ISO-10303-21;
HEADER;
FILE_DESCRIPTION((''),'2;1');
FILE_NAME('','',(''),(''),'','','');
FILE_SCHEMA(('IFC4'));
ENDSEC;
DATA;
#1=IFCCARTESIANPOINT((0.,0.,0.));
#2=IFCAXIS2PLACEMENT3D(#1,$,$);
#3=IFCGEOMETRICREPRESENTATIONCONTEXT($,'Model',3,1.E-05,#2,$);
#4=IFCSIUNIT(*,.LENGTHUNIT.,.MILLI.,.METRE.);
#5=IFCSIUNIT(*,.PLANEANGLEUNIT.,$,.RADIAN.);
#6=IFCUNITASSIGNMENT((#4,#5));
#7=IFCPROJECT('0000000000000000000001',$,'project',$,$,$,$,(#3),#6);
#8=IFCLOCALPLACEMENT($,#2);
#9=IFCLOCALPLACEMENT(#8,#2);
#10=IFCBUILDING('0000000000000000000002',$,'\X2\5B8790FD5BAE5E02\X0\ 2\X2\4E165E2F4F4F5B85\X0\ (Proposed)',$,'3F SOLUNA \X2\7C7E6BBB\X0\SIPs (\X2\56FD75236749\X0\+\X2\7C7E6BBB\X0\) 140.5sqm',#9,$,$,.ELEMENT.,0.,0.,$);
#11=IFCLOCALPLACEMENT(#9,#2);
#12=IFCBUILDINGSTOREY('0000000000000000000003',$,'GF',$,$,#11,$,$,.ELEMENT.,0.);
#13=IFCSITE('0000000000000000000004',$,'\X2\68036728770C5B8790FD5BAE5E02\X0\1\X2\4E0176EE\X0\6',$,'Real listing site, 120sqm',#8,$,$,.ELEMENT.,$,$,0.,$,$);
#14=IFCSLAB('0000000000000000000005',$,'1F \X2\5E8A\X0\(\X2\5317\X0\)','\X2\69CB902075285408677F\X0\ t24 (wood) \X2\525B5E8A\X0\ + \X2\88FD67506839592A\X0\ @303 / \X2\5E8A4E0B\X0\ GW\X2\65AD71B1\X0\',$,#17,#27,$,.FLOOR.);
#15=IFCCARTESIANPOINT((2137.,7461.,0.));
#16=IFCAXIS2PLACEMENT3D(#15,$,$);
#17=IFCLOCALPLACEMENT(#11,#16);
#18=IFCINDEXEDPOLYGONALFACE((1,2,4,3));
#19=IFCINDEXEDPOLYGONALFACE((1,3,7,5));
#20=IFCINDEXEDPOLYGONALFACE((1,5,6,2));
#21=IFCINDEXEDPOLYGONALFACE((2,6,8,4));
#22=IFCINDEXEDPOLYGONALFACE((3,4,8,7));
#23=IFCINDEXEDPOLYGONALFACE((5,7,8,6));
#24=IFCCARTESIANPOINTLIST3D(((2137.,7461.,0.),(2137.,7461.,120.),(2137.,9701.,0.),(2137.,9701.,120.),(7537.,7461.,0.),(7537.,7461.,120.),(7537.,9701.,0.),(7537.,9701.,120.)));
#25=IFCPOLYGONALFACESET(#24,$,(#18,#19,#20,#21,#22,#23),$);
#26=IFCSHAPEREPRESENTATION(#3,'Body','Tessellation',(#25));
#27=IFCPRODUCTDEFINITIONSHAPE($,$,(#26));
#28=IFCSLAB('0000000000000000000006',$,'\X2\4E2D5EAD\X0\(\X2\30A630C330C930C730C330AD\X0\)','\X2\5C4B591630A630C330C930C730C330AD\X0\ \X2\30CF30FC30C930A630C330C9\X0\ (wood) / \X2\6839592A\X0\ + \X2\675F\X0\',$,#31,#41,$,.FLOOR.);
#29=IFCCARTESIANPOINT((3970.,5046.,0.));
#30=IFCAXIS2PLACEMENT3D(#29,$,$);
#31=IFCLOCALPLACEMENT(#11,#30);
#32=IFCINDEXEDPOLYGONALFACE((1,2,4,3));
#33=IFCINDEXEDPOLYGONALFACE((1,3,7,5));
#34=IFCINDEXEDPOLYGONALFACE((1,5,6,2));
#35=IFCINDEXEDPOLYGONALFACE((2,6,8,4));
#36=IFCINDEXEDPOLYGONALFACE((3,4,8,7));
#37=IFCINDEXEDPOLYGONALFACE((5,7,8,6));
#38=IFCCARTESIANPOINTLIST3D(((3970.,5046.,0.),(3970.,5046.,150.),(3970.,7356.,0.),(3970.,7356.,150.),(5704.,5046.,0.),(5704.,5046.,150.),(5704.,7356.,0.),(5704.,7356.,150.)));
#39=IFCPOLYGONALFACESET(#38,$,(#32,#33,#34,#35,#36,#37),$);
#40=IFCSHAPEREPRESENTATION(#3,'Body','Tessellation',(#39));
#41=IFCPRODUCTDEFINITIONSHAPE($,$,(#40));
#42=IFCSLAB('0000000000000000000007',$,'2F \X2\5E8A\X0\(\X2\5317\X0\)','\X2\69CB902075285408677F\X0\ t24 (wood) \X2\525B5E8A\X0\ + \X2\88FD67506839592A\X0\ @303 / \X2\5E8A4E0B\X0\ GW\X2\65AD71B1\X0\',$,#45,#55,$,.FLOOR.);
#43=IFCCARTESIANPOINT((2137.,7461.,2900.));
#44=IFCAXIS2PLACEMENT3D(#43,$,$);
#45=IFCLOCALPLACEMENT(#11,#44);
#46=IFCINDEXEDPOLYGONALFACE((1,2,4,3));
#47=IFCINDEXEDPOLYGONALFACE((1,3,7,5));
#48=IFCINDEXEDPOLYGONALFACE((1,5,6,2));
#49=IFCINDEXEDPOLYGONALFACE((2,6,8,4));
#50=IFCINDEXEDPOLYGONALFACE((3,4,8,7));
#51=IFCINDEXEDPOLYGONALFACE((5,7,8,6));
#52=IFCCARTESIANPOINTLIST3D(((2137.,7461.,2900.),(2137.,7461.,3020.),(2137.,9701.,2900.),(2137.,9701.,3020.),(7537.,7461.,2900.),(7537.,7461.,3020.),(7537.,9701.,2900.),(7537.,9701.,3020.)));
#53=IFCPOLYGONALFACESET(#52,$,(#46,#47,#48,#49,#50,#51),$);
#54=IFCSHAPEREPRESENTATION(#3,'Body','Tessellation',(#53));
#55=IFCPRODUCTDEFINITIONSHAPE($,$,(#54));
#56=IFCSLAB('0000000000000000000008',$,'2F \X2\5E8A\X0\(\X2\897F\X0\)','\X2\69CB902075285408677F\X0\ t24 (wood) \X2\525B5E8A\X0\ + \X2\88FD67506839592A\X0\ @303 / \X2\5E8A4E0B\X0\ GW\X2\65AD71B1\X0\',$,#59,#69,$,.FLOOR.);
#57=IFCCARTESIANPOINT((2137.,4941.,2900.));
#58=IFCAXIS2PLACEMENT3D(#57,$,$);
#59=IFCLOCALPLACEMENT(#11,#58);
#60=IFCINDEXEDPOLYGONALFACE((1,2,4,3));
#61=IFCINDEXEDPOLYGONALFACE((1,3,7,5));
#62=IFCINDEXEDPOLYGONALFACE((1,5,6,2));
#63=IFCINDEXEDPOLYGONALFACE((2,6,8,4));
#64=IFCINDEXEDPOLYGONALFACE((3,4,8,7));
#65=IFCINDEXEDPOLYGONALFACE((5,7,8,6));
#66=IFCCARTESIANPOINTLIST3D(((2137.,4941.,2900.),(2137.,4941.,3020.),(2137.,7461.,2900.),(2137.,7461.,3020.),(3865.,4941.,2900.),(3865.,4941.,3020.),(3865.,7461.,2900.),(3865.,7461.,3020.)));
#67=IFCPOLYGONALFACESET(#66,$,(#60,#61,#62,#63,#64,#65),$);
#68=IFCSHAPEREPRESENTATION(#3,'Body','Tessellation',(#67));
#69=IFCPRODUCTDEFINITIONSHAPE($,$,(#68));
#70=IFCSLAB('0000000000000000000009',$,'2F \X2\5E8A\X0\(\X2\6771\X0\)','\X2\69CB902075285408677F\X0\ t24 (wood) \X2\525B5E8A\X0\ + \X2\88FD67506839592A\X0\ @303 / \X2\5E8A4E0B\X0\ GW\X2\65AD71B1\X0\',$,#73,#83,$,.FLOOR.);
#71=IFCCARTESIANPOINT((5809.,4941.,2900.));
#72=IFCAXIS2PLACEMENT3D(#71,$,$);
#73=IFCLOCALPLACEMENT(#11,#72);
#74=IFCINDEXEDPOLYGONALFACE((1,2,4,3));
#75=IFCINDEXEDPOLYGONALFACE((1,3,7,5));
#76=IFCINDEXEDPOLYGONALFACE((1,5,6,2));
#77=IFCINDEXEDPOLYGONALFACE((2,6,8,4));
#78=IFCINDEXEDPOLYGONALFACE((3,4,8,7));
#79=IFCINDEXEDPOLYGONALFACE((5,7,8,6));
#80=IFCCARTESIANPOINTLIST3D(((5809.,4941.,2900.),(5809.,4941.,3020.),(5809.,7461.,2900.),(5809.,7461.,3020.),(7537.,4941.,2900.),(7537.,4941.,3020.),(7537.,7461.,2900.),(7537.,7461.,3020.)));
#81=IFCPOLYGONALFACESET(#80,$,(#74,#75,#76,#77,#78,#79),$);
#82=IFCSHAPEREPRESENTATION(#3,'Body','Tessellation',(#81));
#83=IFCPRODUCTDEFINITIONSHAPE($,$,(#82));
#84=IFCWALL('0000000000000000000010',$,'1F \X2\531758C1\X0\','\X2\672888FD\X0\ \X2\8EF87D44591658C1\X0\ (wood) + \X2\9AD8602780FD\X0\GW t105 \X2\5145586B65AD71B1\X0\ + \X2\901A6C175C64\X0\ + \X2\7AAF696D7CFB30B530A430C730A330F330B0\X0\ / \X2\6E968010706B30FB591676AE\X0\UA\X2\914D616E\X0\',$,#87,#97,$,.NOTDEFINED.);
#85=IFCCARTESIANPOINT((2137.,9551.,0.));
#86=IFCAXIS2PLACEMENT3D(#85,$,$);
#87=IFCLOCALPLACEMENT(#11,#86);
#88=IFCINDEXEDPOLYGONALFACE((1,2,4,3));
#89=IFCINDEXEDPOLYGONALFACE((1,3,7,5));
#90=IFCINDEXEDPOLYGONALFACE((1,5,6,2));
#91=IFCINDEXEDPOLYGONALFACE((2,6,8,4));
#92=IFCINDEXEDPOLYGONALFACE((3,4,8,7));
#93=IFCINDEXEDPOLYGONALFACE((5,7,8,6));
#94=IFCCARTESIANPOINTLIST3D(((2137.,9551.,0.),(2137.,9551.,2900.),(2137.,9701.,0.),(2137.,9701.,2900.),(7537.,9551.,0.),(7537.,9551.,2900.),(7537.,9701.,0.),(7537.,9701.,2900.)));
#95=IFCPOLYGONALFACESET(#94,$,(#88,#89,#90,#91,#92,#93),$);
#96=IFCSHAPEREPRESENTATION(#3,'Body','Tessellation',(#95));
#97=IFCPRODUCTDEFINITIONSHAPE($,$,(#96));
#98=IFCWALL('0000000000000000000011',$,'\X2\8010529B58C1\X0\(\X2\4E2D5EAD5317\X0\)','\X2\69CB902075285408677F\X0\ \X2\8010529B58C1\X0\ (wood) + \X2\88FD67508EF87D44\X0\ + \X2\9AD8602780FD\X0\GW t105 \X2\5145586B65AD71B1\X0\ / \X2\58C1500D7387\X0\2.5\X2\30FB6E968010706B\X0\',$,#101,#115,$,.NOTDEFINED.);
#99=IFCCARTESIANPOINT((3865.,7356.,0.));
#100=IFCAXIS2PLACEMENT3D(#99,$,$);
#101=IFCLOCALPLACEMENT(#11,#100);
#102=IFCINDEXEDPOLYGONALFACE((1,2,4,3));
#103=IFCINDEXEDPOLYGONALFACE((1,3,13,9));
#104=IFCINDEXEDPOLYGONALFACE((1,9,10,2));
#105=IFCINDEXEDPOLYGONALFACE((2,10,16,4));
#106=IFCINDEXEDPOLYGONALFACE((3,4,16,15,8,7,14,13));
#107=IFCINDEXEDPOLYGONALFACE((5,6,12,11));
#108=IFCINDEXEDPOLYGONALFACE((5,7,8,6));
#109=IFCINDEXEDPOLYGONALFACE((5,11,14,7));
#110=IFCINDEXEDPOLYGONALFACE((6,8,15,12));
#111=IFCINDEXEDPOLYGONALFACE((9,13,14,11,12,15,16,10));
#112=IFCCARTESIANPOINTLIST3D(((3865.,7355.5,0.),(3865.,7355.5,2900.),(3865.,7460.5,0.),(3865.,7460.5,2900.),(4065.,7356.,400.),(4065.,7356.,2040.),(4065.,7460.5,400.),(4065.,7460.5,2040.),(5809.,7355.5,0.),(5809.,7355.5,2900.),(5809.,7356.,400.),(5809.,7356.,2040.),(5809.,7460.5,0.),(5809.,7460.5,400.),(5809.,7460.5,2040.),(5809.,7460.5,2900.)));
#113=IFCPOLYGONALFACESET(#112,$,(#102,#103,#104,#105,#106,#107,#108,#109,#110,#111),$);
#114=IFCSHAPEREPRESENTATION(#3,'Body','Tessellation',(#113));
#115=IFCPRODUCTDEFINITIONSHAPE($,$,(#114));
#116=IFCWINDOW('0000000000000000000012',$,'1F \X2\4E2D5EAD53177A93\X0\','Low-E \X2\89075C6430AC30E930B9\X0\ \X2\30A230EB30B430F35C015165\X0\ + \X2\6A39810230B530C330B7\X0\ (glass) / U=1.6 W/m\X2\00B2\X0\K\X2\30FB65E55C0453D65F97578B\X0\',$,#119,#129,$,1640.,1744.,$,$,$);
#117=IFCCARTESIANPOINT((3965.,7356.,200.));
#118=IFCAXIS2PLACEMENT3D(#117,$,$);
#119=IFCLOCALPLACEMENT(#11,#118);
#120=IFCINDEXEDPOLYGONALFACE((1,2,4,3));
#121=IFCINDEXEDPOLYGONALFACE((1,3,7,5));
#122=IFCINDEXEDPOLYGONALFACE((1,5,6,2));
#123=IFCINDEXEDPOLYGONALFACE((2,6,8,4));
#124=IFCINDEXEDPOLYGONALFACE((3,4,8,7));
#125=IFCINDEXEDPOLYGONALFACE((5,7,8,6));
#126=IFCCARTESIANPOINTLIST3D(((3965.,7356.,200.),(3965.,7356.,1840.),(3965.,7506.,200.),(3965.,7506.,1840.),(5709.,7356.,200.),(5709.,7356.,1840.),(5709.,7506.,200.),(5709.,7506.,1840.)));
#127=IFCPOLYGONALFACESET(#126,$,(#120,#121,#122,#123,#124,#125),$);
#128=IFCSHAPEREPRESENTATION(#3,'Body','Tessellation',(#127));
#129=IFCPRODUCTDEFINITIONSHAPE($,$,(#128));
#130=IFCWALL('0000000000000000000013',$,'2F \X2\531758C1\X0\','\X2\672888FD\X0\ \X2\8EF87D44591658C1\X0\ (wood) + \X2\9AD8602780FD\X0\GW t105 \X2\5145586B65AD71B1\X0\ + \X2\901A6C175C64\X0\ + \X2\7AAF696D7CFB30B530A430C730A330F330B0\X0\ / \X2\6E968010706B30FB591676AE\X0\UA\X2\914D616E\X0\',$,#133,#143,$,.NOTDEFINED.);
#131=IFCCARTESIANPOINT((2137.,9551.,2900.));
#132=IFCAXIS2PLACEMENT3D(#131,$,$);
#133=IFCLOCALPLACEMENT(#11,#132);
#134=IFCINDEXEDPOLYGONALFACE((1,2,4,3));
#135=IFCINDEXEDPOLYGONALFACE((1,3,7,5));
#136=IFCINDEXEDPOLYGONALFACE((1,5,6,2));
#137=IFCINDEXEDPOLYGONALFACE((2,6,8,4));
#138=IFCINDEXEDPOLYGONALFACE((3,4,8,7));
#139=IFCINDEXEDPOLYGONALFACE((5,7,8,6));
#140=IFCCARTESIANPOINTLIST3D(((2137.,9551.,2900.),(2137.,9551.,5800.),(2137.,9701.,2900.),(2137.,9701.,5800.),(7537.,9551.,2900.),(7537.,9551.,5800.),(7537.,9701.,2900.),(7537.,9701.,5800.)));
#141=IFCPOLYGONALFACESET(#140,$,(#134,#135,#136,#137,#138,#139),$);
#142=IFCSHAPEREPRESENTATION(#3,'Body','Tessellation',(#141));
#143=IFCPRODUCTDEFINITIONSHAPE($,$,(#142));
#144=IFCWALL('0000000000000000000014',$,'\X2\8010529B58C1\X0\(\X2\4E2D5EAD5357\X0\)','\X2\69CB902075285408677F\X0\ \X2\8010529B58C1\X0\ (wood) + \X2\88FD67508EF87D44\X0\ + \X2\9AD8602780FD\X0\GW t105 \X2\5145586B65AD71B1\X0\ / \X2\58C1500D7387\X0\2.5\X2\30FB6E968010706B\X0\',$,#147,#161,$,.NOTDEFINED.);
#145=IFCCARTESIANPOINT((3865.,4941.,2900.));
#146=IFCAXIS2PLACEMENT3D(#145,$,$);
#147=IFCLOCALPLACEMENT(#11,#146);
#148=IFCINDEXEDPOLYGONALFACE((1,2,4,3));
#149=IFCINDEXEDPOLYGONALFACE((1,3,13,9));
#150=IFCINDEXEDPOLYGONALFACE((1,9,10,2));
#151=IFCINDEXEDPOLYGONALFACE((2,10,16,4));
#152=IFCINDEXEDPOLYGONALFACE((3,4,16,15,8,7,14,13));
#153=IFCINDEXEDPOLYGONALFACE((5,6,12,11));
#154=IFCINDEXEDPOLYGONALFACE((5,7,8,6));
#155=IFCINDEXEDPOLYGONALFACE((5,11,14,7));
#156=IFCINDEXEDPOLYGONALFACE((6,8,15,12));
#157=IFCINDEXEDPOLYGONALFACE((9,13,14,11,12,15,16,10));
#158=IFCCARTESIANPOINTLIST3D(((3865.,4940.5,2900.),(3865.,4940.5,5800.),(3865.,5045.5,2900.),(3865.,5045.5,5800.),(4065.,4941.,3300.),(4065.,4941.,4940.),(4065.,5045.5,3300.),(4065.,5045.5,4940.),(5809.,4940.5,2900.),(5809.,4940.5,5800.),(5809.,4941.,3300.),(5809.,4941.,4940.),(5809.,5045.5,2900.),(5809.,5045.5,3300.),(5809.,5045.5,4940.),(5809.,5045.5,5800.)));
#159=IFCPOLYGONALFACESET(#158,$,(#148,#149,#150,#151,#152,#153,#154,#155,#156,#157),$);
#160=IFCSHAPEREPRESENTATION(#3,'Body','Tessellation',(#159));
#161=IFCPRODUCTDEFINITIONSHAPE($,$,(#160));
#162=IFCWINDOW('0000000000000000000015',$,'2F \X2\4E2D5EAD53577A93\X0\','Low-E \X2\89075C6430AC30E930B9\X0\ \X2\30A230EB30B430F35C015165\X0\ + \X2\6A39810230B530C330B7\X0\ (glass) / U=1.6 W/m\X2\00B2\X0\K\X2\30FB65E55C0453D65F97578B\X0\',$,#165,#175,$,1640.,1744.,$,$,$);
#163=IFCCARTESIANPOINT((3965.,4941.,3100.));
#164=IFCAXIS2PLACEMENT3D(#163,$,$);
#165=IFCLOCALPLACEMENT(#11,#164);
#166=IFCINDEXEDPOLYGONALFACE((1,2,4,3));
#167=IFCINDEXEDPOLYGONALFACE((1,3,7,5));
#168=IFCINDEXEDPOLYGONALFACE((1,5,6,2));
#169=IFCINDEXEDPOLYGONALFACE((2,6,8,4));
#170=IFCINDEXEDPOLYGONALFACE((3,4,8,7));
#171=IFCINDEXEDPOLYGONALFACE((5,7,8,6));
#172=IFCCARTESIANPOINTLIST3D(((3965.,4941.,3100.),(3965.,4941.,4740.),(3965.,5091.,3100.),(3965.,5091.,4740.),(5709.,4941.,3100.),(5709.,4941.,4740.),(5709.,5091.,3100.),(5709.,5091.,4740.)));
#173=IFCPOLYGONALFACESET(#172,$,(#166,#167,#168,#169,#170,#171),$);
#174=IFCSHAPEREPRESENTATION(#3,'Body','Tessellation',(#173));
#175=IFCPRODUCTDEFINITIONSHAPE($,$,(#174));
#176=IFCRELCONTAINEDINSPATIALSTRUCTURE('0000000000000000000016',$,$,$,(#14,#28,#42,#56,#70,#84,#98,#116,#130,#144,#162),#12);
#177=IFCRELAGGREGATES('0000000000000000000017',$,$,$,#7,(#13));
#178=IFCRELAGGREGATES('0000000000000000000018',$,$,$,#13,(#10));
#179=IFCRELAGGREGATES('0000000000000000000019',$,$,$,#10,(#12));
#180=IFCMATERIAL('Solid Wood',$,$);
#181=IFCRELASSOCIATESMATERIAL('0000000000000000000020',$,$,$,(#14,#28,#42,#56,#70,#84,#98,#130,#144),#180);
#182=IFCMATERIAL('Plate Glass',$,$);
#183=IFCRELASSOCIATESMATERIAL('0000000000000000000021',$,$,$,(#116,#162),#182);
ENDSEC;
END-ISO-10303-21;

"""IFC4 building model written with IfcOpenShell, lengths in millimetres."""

from ifc_helpers import new_model, si_unit, frame, frame_2d, origin, place, context, project, spatial, rectangle, extrude, material, element, fill, save


model = new_model("IFC4")

# Units and contexts
model_context = context("Model", 3, precision=1e-05, world=origin())
ifc_project = project(units=[si_unit("LENGTHUNIT", "METRE", prefix="MILLI"), si_unit("PLANEANGLEUNIT", "RADIAN")], contexts=[model_context])

# Site, building, storey
site_placement = place(None, origin())
site = spatial("IfcSite", under=ifc_project, at=site_placement, Name="栃木県宇都宮市1丁目6", ObjectType="Real listing site, 120sqm", CompositionType="ELEMENT", RefElevation=0.0)
building_placement = place(site_placement, origin())
building = spatial("IfcBuilding", under=site, at=building_placement, Name="宇都宮市 2世帯住宅 (Proposed)", ObjectType="3F SOLUNA 籾殻SIPs (国産杉+籾殻) 140.5sqm", CompositionType="ELEMENT", ElevationOfRefHeight=0.0, ElevationOfTerrain=0.0)
storey_placement = place(building_placement, origin())
storey = spatial("IfcBuildingStorey", under=building, at=storey_placement, Name="GF", CompositionType="ELEMENT", Elevation=0.0)

# Slabs
ifc_material_1 = material(Name="Solid Wood")
slab_1_placement = place(storey_placement, frame((2137.0, 7461.0, 0.0)))
element("IfcSlab", 1, at=slab_1_placement, inside=storey, material=ifc_material_1, Name="1F 床(北)", Description="構造用合板 t24 (wood) 剛床 + 製材根太 @303 / 床下 GW断熱", PredefinedType="FLOOR", context=model_context, shape_type="SweptSolid", body=[
    extrude(rectangle(XDim=5400.0, YDim=2240.0, at=frame_2d((2700.0, 1120.0))), frame((2137.0, 7461.0, 0.0)), (0.0, 0.0, 1.0), 120.0),
])
slab_2_placement = place(storey_placement, frame((3970.0, 5046.0, 0.0)))
element("IfcSlab", 2, at=slab_2_placement, inside=storey, material=ifc_material_1, Name="中庭(ウッドデッキ)", Description="屋外ウッドデッキ ハードウッド (wood) / 根太 + 束", PredefinedType="FLOOR", context=model_context, shape_type="SweptSolid", body=[
    extrude(rectangle(XDim=1734.0, YDim=2310.0, at=frame_2d((867.0, 1155.0))), frame((3970.0, 5046.0, 0.0)), (0.0, 0.0, 1.0), 150.0),
])
slab_3_placement = place(storey_placement, frame((2137.0, 7461.0, 2900.0)))
element("IfcSlab", 3, at=slab_3_placement, inside=storey, material=ifc_material_1, Name="2F 床(北)", Description="構造用合板 t24 (wood) 剛床 + 製材根太 @303 / 床下 GW断熱", PredefinedType="FLOOR", context=model_context, shape_type="SweptSolid", body=[
    extrude(rectangle(XDim=5400.0, YDim=2240.0, at=frame_2d((2700.0, 1120.0))), frame((2137.0, 7461.0, 2900.0)), (0.0, 0.0, 1.0), 120.0),
])
slab_4_placement = place(storey_placement, frame((2137.0, 4941.0, 2900.0)))
element("IfcSlab", 4, at=slab_4_placement, inside=storey, material=ifc_material_1, Name="2F 床(西)", Description="構造用合板 t24 (wood) 剛床 + 製材根太 @303 / 床下 GW断熱", PredefinedType="FLOOR", context=model_context, shape_type="SweptSolid", body=[
    extrude(rectangle(XDim=1728.0, YDim=2520.0, at=frame_2d((864.0, 1260.0))), frame((2137.0, 4941.0, 2900.0)), (0.0, 0.0, 1.0), 120.0),
])
slab_5_placement = place(storey_placement, frame((5809.0, 4941.0, 2900.0)))
element("IfcSlab", 5, at=slab_5_placement, inside=storey, material=ifc_material_1, Name="2F 床(東)", Description="構造用合板 t24 (wood) 剛床 + 製材根太 @303 / 床下 GW断熱", PredefinedType="FLOOR", context=model_context, shape_type="SweptSolid", body=[
    extrude(rectangle(XDim=1728.0, YDim=2520.0, at=frame_2d((864.0, 1260.0))), frame((5809.0, 4941.0, 2900.0)), (0.0, 0.0, 1.0), 120.0),
])

# Wall
wall_1_placement = place(storey_placement, frame((2137.0, 9551.0, 0.0)))
element("IfcWall", 6, at=wall_1_placement, inside=storey, material=ifc_material_1, Name="1F 北壁", Description="木製 軸組外壁 (wood) + 高性能GW t105 充填断熱 + 通気層 + 窯業系サイディング / 準耐火・外皮UA配慮", PredefinedType="NOTDEFINED", context=model_context, shape_type="SweptSolid", body=[
    extrude(rectangle(XDim=5400.0, YDim=150.0, at=frame_2d((2700.0, 75.0))), frame((2137.0, 9551.0, 0.0)), (0.0, 0.0, 1.0), 2900.0),
])

# Wall, opening, window
wall_2_placement = place(storey_placement, frame((3865.0, 7356.0, 0.0)))
wall_2 = element("IfcWall", 7, at=wall_2_placement, inside=storey, material=ifc_material_1, Name="耐力壁(中庭北)", Description="構造用合板 耐力壁 (wood) + 製材軸組 + 高性能GW t105 充填断熱 / 壁倍率2.5・準耐火", PredefinedType="NOTDEFINED", context=model_context, shape_type="SweptSolid", body=[
    extrude(rectangle(XDim=1944.0, YDim=105.0, at=frame_2d((972.0, 52.0))), frame((3865.0, 7356.0, 0.0)), (0.0, 0.0, 1.0), 2900.0),
])
opening_1_placement = place(storey_placement, frame((3965.0, 7356.0, 200.0)))
opening_1 = element("IfcOpeningElement", 8, at=opening_1_placement, cuts=wall_2, PredefinedType="NOTDEFINED", context=model_context, shape_type="SweptSolid", body=[
    extrude(rectangle(XDim=1744.0, YDim=150.0, at=frame_2d((872.0, 75.0))), frame((3965.0, 7356.0, 200.0)), (0.0, 0.0, 1.0), 1640.0),
])
ifc_material_2 = material(Name="Plate Glass")
window_1_placement = place(storey_placement, frame((3965.0, 7356.0, 200.0)))
window_1 = element("IfcWindow", 9, at=window_1_placement, inside=storey, material=ifc_material_2, Name="1F 中庭北窓", Description="Low-E 複層ガラス アルゴン封入 + 樹脂サッシ (glass) / U=1.6 W/m²K・日射取得型", OverallHeight=1640.0, OverallWidth=1744.0, context=model_context, shape_type="SweptSolid", body=[
    extrude(rectangle(XDim=1744.0, YDim=150.0, at=frame_2d((872.0, 75.0))), frame((3965.0, 7356.0, 200.0)), (0.0, 0.0, 1.0), 1640.0),
])
fill(opening_1, window_1)

# Wall
wall_3_placement = place(storey_placement, frame((2137.0, 9551.0, 2900.0)))
element("IfcWall", 10, at=wall_3_placement, inside=storey, material=ifc_material_1, Name="2F 北壁", Description="木製 軸組外壁 (wood) + 高性能GW t105 充填断熱 + 通気層 + 窯業系サイディング / 準耐火・外皮UA配慮", PredefinedType="NOTDEFINED", context=model_context, shape_type="SweptSolid", body=[
    extrude(rectangle(XDim=5400.0, YDim=150.0, at=frame_2d((2700.0, 75.0))), frame((2137.0, 9551.0, 2900.0)), (0.0, 0.0, 1.0), 2900.0),
])

# Wall, opening, window
wall_4_placement = place(storey_placement, frame((3865.0, 4941.0, 2900.0)))
wall_4 = element("IfcWall", 11, at=wall_4_placement, inside=storey, material=ifc_material_1, Name="耐力壁(中庭南)", Description="構造用合板 耐力壁 (wood) + 製材軸組 + 高性能GW t105 充填断熱 / 壁倍率2.5・準耐火", PredefinedType="NOTDEFINED", context=model_context, shape_type="SweptSolid", body=[
    extrude(rectangle(XDim=1944.0, YDim=105.0, at=frame_2d((972.0, 52.0))), frame((3865.0, 4941.0, 2900.0)), (0.0, 0.0, 1.0), 2900.0),
])
opening_2_placement = place(storey_placement, frame((3965.0, 4941.0, 3100.0)))
opening_2 = element("IfcOpeningElement", 12, at=opening_2_placement, cuts=wall_4, PredefinedType="NOTDEFINED", context=model_context, shape_type="SweptSolid", body=[
    extrude(rectangle(XDim=1744.0, YDim=150.0, at=frame_2d((872.0, 75.0))), frame((3965.0, 4941.0, 3100.0)), (0.0, 0.0, 1.0), 1640.0),
])
window_2_placement = place(storey_placement, frame((3965.0, 4941.0, 3100.0)))
window_2 = element("IfcWindow", 13, at=window_2_placement, inside=storey, material=ifc_material_2, Name="2F 中庭南窓", Description="Low-E 複層ガラス アルゴン封入 + 樹脂サッシ (glass) / U=1.6 W/m²K・日射取得型", OverallHeight=1640.0, OverallWidth=1744.0, context=model_context, shape_type="SweptSolid", body=[
    extrude(rectangle(XDim=1744.0, YDim=150.0, at=frame_2d((872.0, 75.0))), frame((3965.0, 4941.0, 3100.0)), (0.0, 0.0, 1.0), 1640.0),
])
fill(opening_2, window_2)

save(model, "model.ifc")
